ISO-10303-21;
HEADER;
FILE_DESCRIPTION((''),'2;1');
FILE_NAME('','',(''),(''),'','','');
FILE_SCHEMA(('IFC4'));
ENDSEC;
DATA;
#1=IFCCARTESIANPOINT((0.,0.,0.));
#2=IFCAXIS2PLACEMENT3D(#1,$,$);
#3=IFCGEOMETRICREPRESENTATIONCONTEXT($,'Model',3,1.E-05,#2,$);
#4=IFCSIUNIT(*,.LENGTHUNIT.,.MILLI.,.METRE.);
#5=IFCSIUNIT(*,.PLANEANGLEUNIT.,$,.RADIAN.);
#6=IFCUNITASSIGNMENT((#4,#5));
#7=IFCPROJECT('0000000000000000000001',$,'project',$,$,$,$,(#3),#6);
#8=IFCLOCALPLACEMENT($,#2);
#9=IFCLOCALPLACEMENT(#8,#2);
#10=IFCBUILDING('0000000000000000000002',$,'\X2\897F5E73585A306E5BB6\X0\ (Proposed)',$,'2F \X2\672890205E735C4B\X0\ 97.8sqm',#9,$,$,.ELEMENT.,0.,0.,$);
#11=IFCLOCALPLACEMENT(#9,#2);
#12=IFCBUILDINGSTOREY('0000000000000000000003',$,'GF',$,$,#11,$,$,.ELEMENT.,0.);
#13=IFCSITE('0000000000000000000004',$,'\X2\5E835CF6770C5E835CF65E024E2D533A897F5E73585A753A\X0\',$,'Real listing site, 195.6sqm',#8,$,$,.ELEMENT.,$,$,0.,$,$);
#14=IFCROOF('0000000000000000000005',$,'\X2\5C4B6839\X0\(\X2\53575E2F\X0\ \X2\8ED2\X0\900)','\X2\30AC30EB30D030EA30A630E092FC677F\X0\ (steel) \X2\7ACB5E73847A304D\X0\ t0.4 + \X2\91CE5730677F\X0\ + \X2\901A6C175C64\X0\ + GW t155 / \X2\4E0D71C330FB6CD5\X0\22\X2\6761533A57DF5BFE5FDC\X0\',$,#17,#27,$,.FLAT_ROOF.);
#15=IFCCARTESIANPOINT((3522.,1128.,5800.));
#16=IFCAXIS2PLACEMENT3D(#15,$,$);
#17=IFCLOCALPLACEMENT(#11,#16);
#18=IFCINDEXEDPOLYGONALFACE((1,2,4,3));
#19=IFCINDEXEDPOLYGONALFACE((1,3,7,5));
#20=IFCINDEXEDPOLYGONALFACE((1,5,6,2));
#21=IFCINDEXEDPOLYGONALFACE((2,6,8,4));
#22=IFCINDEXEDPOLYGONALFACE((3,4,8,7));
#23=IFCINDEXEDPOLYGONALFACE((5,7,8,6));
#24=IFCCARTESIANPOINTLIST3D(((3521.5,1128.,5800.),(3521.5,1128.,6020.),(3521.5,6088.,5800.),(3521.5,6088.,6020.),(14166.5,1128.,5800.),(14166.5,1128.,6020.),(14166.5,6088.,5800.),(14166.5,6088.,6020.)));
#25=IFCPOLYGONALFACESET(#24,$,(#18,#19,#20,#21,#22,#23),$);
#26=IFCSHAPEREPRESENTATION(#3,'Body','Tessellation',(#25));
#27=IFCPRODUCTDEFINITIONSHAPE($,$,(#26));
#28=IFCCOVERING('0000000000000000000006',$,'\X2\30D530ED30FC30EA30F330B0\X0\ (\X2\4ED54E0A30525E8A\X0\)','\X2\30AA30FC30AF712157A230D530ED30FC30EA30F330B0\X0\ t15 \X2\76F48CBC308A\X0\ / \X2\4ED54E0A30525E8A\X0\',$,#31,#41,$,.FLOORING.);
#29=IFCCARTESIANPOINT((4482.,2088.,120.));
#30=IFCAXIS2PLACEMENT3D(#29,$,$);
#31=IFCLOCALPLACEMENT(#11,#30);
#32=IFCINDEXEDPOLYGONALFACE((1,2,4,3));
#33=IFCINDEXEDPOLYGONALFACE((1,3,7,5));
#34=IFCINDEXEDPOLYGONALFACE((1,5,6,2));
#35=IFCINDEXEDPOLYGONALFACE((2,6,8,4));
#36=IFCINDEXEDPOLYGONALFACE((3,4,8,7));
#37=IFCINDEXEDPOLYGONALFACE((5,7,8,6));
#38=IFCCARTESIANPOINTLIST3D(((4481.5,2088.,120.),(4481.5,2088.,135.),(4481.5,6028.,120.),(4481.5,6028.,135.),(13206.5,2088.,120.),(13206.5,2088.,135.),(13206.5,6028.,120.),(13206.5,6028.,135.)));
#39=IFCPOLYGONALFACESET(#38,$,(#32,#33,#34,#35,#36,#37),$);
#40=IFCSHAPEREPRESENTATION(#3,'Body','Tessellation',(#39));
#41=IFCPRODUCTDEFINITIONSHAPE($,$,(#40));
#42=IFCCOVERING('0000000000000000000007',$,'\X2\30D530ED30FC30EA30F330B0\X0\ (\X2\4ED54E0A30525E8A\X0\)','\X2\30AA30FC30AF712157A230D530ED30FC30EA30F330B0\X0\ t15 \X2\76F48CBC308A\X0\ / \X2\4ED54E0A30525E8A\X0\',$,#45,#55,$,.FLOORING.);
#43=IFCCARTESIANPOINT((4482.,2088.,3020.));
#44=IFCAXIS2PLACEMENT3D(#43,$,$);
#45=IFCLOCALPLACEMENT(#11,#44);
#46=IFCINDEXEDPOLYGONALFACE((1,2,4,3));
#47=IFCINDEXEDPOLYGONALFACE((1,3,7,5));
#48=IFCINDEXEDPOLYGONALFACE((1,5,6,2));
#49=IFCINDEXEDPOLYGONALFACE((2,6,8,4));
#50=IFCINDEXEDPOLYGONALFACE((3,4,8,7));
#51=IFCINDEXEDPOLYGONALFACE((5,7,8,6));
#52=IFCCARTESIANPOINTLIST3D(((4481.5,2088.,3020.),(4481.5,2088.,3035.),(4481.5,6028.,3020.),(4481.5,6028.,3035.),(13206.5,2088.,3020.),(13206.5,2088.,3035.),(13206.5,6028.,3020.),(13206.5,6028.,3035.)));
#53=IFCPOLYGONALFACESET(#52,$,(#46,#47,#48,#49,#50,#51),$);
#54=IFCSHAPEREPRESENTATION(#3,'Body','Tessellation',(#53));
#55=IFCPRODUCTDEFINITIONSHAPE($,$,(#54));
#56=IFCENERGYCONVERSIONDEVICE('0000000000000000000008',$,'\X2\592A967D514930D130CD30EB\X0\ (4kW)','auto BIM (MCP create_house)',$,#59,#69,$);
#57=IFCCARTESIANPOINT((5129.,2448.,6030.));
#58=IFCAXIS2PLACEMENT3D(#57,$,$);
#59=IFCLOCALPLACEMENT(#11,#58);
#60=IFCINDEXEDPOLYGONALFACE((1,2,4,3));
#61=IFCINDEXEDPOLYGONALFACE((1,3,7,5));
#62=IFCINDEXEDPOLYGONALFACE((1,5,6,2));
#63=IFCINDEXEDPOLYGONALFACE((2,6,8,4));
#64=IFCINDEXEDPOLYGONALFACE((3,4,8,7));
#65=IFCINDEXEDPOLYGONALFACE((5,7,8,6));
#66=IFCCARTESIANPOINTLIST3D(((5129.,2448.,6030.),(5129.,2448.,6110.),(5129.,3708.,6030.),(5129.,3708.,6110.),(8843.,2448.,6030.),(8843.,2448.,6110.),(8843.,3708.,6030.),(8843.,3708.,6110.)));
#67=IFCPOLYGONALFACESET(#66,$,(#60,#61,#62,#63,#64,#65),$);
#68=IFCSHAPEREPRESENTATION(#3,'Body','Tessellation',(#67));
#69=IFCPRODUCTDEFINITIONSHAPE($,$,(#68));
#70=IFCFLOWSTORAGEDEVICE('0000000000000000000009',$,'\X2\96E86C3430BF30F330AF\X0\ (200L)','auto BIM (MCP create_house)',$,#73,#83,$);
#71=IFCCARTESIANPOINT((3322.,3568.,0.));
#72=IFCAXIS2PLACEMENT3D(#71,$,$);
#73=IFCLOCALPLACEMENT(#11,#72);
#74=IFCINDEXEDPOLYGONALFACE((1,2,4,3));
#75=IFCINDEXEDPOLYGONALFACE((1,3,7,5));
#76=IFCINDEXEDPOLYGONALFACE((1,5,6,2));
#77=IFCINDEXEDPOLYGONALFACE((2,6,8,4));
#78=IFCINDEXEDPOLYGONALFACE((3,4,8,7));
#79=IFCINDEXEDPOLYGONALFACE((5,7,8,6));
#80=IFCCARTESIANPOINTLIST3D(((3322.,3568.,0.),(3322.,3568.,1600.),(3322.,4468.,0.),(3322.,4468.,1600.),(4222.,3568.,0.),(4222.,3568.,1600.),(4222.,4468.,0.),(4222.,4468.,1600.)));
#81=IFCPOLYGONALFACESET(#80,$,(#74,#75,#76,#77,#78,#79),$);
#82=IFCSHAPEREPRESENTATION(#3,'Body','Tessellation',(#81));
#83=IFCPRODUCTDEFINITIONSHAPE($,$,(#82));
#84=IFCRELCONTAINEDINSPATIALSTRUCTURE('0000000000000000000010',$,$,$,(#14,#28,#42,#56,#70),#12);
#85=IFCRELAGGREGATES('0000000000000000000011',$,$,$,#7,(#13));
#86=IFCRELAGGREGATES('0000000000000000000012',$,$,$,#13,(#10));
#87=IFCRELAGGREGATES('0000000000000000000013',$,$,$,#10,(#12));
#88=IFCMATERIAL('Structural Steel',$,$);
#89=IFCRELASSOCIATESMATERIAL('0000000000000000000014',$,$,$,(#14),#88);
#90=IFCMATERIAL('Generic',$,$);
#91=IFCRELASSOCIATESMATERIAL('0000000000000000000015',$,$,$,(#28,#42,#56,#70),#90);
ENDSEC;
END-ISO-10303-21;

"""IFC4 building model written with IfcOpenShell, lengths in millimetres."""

from ifc_helpers import new_model, si_unit, frame, frame_2d, origin, place, context, project, spatial, rectangle, extrude, material, element, save


model = new_model("IFC4")

# Units and contexts
model_context = context("Model", 3, precision=1e-05, world=origin())
ifc_project = project(units=[si_unit("LENGTHUNIT", "METRE", prefix="MILLI"), si_unit("PLANEANGLEUNIT", "RADIAN")], contexts=[model_context])

# Site, building, storey
site_placement = place(None, origin())
site = spatial("IfcSite", under=ifc_project, at=site_placement, Name="広島県広島市中区西平塚町", ObjectType="Real listing site, 195.6sqm", CompositionType="ELEMENT", RefElevation=0.0)
building_placement = place(site_placement, origin())
building = spatial("IfcBuilding", under=site, at=building_placement, Name="西平塚の家 (Proposed)", ObjectType="2F 木造平屋 97.8sqm", CompositionType="ELEMENT", ElevationOfRefHeight=0.0, ElevationOfTerrain=0.0)
storey_placement = place(building_placement, origin())
storey = spatial("IfcBuildingStorey", under=building, at=storey_placement, Name="GF", CompositionType="ELEMENT", Elevation=0.0)

# Roof
ifc_material_1 = material(Name="Structural Steel")
for number, where, name in (
    (1, (3522.0, 1128.0, 5800.0), "屋根(南帯 軒900)"),
):
    element("IfcRoof", number, at=place(storey_placement, frame(where)), inside=storey, material=ifc_material_1, Name=name, Description="ガルバリウム鋼板 (steel) 立平葺き t0.4 + 野地板 + 通気層 + GW t155 / 不燃・法22条区域対応", PredefinedType="FLAT_ROOF", context=model_context, shape_type="SweptSolid", body=[
        extrude(rectangle(XDim=10645.0, YDim=4960.0, at=frame_2d((5322.0, 2480.0))), frame((3522.0, 1128.0, 5800.0)), (0.0, 0.0, 1.0), 220.0),
    ])

# Coverings
ifc_material_2 = material(Name="Generic")
covering_1_placement = place(storey_placement, frame((4482.0, 2088.0, 120.0)))
element("IfcCovering", 2, at=covering_1_placement, inside=storey, material=ifc_material_2, Name="フローリング (仕上げ床)", Description="オーク無垢フローリング t15 直貼り / 仕上げ床", PredefinedType="FLOORING", context=model_context, shape_type="SweptSolid", body=[
    extrude(rectangle(XDim=8725.0, YDim=3940.0, at=frame_2d((4362.0, 1970.0))), frame((4482.0, 2088.0, 120.0)), (0.0, 0.0, 1.0), 15.0),
])
covering_2_placement = place(storey_placement, frame((4482.0, 2088.0, 3020.0)))
element("IfcCovering", 3, at=covering_2_placement, inside=storey, material=ifc_material_2, Name="フローリング (仕上げ床)", Description="オーク無垢フローリング t15 直貼り / 仕上げ床", PredefinedType="FLOORING", context=model_context, shape_type="SweptSolid", body=[
    extrude(rectangle(XDim=8725.0, YDim=3940.0, at=frame_2d((4362.0, 1970.0))), frame((4482.0, 2088.0, 3020.0)), (0.0, 0.0, 1.0), 15.0),
])

# Energy conversion device
energy_conversion_device_placement = place(storey_placement, frame((5129.0, 2448.0, 6030.0)))
element("IfcEnergyConversionDevice", 4, at=energy_conversion_device_placement, inside=storey, material=ifc_material_2, Name="太陽光パネル (4kW)", Description="auto BIM (MCP create_house)", context=model_context, shape_type="SweptSolid", body=[
    extrude(rectangle(XDim=3714.0, YDim=1260.0, at=frame_2d((1857.0, 630.0))), frame((5129.0, 2448.0, 6030.0)), (0.0, 0.0, 1.0), 80.0),
])

# Flow storage device
flow_storage_device_placement = place(storey_placement, frame((3322.0, 3568.0, 0.0)))
element("IfcFlowStorageDevice", 5, at=flow_storage_device_placement, inside=storey, material=ifc_material_2, Name="雨水タンク (200L)", Description="auto BIM (MCP create_house)", context=model_context, shape_type="SweptSolid", body=[
    extrude(rectangle(XDim=900.0, YDim=900.0, at=frame_2d((450.0, 450.0))), frame((3322.0, 3568.0, 0.0)), (0.0, 0.0, 1.0), 1600.0),
])

save(model, "model.ifc")
